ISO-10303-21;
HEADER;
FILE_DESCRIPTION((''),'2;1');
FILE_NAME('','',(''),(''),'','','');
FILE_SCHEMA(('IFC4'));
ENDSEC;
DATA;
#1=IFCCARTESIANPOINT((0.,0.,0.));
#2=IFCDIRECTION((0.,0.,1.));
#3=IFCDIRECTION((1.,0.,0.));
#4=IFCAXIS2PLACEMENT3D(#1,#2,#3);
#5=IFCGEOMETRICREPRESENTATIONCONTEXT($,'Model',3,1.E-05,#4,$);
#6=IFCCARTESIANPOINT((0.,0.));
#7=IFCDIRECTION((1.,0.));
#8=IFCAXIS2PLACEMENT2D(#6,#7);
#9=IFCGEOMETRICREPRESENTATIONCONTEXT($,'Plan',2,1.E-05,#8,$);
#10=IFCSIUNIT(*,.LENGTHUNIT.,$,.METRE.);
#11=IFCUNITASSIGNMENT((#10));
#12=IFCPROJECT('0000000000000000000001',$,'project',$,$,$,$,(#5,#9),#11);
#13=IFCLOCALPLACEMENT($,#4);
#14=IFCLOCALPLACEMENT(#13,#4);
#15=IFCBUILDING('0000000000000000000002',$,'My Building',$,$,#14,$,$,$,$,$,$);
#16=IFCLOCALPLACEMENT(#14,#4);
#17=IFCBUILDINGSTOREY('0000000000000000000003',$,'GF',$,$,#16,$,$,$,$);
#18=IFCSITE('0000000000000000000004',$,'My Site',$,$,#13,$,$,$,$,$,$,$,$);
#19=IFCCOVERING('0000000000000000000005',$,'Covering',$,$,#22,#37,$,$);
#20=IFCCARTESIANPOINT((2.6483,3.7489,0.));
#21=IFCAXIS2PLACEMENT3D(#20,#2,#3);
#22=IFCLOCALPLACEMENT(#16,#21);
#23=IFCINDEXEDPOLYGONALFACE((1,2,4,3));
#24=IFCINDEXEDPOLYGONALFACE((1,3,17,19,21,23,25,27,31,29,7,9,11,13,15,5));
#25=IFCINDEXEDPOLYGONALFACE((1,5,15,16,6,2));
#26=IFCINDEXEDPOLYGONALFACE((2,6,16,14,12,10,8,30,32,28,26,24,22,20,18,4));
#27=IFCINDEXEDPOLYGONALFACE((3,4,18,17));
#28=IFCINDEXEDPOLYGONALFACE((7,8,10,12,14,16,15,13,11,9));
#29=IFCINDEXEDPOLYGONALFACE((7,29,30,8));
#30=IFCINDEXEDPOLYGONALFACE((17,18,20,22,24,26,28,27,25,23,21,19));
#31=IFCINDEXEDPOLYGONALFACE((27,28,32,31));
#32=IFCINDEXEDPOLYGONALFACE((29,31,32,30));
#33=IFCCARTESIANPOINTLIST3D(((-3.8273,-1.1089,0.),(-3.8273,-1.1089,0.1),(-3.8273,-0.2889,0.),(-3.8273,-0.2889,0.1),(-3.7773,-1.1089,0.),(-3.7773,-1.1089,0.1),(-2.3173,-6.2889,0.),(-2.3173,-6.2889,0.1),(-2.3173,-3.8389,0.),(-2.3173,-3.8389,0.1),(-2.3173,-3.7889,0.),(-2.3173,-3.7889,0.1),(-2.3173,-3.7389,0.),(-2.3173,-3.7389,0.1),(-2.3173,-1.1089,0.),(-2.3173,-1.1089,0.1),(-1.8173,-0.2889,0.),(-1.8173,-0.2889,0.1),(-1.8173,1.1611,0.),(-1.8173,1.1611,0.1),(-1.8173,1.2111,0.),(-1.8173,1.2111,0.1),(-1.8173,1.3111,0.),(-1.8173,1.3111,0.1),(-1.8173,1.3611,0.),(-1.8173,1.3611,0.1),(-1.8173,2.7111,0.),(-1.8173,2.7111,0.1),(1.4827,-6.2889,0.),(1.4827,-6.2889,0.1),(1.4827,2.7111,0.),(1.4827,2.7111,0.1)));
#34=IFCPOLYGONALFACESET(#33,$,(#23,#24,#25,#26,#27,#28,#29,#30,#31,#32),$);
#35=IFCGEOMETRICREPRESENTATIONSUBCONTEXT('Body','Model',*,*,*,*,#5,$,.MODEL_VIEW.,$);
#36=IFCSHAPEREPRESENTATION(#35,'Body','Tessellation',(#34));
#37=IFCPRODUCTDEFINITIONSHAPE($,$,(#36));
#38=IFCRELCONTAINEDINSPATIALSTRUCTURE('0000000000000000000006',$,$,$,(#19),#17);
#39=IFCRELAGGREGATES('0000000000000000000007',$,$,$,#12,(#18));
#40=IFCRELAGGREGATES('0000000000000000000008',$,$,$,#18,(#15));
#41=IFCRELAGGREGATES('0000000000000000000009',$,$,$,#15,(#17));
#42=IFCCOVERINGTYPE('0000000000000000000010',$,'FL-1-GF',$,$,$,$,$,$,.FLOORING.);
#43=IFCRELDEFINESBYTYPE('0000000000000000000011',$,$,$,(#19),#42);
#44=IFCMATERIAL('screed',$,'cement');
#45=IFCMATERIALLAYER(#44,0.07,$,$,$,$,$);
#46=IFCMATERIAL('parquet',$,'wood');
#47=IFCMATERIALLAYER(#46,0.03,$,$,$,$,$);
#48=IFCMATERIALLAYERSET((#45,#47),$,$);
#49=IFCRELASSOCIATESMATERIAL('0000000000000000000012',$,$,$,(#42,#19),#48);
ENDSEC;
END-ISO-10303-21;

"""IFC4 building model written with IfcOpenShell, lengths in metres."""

from ifc_helpers import new_model, si_unit, frame, origin_with_axes, origin_2d_with_axis, place, context, subcontext, project, spatial, line, indexed_curve, outline, extrude, material, layer, layer_set, layer_usage, type_object, element, save


model = new_model("IFC4")

# Units and contexts
model_context = context("Model", 3, precision=1e-05, world=origin_with_axes())
plan_context = context("Plan", 2, precision=1e-05, world=origin_2d_with_axis())
body_context_1 = subcontext(model_context, "Body", "Model", "MODEL_VIEW")
ifc_project = project(units=[si_unit("LENGTHUNIT", "METRE")], contexts=[model_context, plan_context])

# Site, building, storey
site_placement = place(None, origin_with_axes())
site = spatial("IfcSite", under=ifc_project, at=site_placement, Name="My Site")
building_placement = place(site_placement, origin_with_axes())
building = spatial("IfcBuilding", under=site, at=building_placement, Name="My Building")
storey_placement = place(building_placement, origin_with_axes())
storey = spatial("IfcBuildingStorey", under=building, at=storey_placement, Name="GF")

# Covering
ifc_material_1 = material(Name="screed", Category="cement")
ifc_layer_1 = layer(ifc_material_1, 0.07)
ifc_material_2 = material(Name="parquet", Category="wood")
ifc_layer_2 = layer(ifc_material_2, 0.03)
ifc_layer_set_1 = layer_set([ifc_layer_1, ifc_layer_2])
ifc_layer_usage_1 = layer_usage(ifc_layer_set_1, "AXIS3", "POSITIVE", 0.0)
covering_type = type_object("IfcCoveringType", Name="FL-1-GF", PredefinedType="FLOORING", material=ifc_layer_set_1)
covering_placement = place(storey_placement, frame((2.6483, 3.7489, 0.0), z_axis=(0.0, 0.0, 1.0), x_axis=(1.0, 0.0, 0.0)))
element("IfcCovering", 1, at=covering_placement, inside=storey, type_object=covering_type, material=ifc_layer_usage_1, Name="Covering", context=body_context_1, shape_type="SweptSolid", body=[
    extrude(outline(indexed_curve([(-2.3173, -1.1089), (-3.7773, -1.1089), (-3.8273, -1.1089), (-3.8273, -0.2889), (-1.8173, -0.2889), (-1.8173, 1.1611), (-1.8173, 1.2111), (-1.8173, 1.3111), (-1.8173, 1.3611), (-1.8173, 2.7111), (1.4827, 2.7111), (1.4827, -6.2889), (-2.3173, -6.2889), (-2.3173, -6.2889), (-2.3173, -3.8389), (-2.3173, -3.7889), (-2.3173, -3.7889), (-2.3173, -3.7389)], segments=[line(1, 2, 3, 4, 5, 6, 7, 8, 9, 10, 11, 12, 13, 14, 15, 16, 17, 18, 1)])), origin_with_axes(), (0.0, 0.0, 1.0), 0.1),
])

save(model, "model.ifc")
